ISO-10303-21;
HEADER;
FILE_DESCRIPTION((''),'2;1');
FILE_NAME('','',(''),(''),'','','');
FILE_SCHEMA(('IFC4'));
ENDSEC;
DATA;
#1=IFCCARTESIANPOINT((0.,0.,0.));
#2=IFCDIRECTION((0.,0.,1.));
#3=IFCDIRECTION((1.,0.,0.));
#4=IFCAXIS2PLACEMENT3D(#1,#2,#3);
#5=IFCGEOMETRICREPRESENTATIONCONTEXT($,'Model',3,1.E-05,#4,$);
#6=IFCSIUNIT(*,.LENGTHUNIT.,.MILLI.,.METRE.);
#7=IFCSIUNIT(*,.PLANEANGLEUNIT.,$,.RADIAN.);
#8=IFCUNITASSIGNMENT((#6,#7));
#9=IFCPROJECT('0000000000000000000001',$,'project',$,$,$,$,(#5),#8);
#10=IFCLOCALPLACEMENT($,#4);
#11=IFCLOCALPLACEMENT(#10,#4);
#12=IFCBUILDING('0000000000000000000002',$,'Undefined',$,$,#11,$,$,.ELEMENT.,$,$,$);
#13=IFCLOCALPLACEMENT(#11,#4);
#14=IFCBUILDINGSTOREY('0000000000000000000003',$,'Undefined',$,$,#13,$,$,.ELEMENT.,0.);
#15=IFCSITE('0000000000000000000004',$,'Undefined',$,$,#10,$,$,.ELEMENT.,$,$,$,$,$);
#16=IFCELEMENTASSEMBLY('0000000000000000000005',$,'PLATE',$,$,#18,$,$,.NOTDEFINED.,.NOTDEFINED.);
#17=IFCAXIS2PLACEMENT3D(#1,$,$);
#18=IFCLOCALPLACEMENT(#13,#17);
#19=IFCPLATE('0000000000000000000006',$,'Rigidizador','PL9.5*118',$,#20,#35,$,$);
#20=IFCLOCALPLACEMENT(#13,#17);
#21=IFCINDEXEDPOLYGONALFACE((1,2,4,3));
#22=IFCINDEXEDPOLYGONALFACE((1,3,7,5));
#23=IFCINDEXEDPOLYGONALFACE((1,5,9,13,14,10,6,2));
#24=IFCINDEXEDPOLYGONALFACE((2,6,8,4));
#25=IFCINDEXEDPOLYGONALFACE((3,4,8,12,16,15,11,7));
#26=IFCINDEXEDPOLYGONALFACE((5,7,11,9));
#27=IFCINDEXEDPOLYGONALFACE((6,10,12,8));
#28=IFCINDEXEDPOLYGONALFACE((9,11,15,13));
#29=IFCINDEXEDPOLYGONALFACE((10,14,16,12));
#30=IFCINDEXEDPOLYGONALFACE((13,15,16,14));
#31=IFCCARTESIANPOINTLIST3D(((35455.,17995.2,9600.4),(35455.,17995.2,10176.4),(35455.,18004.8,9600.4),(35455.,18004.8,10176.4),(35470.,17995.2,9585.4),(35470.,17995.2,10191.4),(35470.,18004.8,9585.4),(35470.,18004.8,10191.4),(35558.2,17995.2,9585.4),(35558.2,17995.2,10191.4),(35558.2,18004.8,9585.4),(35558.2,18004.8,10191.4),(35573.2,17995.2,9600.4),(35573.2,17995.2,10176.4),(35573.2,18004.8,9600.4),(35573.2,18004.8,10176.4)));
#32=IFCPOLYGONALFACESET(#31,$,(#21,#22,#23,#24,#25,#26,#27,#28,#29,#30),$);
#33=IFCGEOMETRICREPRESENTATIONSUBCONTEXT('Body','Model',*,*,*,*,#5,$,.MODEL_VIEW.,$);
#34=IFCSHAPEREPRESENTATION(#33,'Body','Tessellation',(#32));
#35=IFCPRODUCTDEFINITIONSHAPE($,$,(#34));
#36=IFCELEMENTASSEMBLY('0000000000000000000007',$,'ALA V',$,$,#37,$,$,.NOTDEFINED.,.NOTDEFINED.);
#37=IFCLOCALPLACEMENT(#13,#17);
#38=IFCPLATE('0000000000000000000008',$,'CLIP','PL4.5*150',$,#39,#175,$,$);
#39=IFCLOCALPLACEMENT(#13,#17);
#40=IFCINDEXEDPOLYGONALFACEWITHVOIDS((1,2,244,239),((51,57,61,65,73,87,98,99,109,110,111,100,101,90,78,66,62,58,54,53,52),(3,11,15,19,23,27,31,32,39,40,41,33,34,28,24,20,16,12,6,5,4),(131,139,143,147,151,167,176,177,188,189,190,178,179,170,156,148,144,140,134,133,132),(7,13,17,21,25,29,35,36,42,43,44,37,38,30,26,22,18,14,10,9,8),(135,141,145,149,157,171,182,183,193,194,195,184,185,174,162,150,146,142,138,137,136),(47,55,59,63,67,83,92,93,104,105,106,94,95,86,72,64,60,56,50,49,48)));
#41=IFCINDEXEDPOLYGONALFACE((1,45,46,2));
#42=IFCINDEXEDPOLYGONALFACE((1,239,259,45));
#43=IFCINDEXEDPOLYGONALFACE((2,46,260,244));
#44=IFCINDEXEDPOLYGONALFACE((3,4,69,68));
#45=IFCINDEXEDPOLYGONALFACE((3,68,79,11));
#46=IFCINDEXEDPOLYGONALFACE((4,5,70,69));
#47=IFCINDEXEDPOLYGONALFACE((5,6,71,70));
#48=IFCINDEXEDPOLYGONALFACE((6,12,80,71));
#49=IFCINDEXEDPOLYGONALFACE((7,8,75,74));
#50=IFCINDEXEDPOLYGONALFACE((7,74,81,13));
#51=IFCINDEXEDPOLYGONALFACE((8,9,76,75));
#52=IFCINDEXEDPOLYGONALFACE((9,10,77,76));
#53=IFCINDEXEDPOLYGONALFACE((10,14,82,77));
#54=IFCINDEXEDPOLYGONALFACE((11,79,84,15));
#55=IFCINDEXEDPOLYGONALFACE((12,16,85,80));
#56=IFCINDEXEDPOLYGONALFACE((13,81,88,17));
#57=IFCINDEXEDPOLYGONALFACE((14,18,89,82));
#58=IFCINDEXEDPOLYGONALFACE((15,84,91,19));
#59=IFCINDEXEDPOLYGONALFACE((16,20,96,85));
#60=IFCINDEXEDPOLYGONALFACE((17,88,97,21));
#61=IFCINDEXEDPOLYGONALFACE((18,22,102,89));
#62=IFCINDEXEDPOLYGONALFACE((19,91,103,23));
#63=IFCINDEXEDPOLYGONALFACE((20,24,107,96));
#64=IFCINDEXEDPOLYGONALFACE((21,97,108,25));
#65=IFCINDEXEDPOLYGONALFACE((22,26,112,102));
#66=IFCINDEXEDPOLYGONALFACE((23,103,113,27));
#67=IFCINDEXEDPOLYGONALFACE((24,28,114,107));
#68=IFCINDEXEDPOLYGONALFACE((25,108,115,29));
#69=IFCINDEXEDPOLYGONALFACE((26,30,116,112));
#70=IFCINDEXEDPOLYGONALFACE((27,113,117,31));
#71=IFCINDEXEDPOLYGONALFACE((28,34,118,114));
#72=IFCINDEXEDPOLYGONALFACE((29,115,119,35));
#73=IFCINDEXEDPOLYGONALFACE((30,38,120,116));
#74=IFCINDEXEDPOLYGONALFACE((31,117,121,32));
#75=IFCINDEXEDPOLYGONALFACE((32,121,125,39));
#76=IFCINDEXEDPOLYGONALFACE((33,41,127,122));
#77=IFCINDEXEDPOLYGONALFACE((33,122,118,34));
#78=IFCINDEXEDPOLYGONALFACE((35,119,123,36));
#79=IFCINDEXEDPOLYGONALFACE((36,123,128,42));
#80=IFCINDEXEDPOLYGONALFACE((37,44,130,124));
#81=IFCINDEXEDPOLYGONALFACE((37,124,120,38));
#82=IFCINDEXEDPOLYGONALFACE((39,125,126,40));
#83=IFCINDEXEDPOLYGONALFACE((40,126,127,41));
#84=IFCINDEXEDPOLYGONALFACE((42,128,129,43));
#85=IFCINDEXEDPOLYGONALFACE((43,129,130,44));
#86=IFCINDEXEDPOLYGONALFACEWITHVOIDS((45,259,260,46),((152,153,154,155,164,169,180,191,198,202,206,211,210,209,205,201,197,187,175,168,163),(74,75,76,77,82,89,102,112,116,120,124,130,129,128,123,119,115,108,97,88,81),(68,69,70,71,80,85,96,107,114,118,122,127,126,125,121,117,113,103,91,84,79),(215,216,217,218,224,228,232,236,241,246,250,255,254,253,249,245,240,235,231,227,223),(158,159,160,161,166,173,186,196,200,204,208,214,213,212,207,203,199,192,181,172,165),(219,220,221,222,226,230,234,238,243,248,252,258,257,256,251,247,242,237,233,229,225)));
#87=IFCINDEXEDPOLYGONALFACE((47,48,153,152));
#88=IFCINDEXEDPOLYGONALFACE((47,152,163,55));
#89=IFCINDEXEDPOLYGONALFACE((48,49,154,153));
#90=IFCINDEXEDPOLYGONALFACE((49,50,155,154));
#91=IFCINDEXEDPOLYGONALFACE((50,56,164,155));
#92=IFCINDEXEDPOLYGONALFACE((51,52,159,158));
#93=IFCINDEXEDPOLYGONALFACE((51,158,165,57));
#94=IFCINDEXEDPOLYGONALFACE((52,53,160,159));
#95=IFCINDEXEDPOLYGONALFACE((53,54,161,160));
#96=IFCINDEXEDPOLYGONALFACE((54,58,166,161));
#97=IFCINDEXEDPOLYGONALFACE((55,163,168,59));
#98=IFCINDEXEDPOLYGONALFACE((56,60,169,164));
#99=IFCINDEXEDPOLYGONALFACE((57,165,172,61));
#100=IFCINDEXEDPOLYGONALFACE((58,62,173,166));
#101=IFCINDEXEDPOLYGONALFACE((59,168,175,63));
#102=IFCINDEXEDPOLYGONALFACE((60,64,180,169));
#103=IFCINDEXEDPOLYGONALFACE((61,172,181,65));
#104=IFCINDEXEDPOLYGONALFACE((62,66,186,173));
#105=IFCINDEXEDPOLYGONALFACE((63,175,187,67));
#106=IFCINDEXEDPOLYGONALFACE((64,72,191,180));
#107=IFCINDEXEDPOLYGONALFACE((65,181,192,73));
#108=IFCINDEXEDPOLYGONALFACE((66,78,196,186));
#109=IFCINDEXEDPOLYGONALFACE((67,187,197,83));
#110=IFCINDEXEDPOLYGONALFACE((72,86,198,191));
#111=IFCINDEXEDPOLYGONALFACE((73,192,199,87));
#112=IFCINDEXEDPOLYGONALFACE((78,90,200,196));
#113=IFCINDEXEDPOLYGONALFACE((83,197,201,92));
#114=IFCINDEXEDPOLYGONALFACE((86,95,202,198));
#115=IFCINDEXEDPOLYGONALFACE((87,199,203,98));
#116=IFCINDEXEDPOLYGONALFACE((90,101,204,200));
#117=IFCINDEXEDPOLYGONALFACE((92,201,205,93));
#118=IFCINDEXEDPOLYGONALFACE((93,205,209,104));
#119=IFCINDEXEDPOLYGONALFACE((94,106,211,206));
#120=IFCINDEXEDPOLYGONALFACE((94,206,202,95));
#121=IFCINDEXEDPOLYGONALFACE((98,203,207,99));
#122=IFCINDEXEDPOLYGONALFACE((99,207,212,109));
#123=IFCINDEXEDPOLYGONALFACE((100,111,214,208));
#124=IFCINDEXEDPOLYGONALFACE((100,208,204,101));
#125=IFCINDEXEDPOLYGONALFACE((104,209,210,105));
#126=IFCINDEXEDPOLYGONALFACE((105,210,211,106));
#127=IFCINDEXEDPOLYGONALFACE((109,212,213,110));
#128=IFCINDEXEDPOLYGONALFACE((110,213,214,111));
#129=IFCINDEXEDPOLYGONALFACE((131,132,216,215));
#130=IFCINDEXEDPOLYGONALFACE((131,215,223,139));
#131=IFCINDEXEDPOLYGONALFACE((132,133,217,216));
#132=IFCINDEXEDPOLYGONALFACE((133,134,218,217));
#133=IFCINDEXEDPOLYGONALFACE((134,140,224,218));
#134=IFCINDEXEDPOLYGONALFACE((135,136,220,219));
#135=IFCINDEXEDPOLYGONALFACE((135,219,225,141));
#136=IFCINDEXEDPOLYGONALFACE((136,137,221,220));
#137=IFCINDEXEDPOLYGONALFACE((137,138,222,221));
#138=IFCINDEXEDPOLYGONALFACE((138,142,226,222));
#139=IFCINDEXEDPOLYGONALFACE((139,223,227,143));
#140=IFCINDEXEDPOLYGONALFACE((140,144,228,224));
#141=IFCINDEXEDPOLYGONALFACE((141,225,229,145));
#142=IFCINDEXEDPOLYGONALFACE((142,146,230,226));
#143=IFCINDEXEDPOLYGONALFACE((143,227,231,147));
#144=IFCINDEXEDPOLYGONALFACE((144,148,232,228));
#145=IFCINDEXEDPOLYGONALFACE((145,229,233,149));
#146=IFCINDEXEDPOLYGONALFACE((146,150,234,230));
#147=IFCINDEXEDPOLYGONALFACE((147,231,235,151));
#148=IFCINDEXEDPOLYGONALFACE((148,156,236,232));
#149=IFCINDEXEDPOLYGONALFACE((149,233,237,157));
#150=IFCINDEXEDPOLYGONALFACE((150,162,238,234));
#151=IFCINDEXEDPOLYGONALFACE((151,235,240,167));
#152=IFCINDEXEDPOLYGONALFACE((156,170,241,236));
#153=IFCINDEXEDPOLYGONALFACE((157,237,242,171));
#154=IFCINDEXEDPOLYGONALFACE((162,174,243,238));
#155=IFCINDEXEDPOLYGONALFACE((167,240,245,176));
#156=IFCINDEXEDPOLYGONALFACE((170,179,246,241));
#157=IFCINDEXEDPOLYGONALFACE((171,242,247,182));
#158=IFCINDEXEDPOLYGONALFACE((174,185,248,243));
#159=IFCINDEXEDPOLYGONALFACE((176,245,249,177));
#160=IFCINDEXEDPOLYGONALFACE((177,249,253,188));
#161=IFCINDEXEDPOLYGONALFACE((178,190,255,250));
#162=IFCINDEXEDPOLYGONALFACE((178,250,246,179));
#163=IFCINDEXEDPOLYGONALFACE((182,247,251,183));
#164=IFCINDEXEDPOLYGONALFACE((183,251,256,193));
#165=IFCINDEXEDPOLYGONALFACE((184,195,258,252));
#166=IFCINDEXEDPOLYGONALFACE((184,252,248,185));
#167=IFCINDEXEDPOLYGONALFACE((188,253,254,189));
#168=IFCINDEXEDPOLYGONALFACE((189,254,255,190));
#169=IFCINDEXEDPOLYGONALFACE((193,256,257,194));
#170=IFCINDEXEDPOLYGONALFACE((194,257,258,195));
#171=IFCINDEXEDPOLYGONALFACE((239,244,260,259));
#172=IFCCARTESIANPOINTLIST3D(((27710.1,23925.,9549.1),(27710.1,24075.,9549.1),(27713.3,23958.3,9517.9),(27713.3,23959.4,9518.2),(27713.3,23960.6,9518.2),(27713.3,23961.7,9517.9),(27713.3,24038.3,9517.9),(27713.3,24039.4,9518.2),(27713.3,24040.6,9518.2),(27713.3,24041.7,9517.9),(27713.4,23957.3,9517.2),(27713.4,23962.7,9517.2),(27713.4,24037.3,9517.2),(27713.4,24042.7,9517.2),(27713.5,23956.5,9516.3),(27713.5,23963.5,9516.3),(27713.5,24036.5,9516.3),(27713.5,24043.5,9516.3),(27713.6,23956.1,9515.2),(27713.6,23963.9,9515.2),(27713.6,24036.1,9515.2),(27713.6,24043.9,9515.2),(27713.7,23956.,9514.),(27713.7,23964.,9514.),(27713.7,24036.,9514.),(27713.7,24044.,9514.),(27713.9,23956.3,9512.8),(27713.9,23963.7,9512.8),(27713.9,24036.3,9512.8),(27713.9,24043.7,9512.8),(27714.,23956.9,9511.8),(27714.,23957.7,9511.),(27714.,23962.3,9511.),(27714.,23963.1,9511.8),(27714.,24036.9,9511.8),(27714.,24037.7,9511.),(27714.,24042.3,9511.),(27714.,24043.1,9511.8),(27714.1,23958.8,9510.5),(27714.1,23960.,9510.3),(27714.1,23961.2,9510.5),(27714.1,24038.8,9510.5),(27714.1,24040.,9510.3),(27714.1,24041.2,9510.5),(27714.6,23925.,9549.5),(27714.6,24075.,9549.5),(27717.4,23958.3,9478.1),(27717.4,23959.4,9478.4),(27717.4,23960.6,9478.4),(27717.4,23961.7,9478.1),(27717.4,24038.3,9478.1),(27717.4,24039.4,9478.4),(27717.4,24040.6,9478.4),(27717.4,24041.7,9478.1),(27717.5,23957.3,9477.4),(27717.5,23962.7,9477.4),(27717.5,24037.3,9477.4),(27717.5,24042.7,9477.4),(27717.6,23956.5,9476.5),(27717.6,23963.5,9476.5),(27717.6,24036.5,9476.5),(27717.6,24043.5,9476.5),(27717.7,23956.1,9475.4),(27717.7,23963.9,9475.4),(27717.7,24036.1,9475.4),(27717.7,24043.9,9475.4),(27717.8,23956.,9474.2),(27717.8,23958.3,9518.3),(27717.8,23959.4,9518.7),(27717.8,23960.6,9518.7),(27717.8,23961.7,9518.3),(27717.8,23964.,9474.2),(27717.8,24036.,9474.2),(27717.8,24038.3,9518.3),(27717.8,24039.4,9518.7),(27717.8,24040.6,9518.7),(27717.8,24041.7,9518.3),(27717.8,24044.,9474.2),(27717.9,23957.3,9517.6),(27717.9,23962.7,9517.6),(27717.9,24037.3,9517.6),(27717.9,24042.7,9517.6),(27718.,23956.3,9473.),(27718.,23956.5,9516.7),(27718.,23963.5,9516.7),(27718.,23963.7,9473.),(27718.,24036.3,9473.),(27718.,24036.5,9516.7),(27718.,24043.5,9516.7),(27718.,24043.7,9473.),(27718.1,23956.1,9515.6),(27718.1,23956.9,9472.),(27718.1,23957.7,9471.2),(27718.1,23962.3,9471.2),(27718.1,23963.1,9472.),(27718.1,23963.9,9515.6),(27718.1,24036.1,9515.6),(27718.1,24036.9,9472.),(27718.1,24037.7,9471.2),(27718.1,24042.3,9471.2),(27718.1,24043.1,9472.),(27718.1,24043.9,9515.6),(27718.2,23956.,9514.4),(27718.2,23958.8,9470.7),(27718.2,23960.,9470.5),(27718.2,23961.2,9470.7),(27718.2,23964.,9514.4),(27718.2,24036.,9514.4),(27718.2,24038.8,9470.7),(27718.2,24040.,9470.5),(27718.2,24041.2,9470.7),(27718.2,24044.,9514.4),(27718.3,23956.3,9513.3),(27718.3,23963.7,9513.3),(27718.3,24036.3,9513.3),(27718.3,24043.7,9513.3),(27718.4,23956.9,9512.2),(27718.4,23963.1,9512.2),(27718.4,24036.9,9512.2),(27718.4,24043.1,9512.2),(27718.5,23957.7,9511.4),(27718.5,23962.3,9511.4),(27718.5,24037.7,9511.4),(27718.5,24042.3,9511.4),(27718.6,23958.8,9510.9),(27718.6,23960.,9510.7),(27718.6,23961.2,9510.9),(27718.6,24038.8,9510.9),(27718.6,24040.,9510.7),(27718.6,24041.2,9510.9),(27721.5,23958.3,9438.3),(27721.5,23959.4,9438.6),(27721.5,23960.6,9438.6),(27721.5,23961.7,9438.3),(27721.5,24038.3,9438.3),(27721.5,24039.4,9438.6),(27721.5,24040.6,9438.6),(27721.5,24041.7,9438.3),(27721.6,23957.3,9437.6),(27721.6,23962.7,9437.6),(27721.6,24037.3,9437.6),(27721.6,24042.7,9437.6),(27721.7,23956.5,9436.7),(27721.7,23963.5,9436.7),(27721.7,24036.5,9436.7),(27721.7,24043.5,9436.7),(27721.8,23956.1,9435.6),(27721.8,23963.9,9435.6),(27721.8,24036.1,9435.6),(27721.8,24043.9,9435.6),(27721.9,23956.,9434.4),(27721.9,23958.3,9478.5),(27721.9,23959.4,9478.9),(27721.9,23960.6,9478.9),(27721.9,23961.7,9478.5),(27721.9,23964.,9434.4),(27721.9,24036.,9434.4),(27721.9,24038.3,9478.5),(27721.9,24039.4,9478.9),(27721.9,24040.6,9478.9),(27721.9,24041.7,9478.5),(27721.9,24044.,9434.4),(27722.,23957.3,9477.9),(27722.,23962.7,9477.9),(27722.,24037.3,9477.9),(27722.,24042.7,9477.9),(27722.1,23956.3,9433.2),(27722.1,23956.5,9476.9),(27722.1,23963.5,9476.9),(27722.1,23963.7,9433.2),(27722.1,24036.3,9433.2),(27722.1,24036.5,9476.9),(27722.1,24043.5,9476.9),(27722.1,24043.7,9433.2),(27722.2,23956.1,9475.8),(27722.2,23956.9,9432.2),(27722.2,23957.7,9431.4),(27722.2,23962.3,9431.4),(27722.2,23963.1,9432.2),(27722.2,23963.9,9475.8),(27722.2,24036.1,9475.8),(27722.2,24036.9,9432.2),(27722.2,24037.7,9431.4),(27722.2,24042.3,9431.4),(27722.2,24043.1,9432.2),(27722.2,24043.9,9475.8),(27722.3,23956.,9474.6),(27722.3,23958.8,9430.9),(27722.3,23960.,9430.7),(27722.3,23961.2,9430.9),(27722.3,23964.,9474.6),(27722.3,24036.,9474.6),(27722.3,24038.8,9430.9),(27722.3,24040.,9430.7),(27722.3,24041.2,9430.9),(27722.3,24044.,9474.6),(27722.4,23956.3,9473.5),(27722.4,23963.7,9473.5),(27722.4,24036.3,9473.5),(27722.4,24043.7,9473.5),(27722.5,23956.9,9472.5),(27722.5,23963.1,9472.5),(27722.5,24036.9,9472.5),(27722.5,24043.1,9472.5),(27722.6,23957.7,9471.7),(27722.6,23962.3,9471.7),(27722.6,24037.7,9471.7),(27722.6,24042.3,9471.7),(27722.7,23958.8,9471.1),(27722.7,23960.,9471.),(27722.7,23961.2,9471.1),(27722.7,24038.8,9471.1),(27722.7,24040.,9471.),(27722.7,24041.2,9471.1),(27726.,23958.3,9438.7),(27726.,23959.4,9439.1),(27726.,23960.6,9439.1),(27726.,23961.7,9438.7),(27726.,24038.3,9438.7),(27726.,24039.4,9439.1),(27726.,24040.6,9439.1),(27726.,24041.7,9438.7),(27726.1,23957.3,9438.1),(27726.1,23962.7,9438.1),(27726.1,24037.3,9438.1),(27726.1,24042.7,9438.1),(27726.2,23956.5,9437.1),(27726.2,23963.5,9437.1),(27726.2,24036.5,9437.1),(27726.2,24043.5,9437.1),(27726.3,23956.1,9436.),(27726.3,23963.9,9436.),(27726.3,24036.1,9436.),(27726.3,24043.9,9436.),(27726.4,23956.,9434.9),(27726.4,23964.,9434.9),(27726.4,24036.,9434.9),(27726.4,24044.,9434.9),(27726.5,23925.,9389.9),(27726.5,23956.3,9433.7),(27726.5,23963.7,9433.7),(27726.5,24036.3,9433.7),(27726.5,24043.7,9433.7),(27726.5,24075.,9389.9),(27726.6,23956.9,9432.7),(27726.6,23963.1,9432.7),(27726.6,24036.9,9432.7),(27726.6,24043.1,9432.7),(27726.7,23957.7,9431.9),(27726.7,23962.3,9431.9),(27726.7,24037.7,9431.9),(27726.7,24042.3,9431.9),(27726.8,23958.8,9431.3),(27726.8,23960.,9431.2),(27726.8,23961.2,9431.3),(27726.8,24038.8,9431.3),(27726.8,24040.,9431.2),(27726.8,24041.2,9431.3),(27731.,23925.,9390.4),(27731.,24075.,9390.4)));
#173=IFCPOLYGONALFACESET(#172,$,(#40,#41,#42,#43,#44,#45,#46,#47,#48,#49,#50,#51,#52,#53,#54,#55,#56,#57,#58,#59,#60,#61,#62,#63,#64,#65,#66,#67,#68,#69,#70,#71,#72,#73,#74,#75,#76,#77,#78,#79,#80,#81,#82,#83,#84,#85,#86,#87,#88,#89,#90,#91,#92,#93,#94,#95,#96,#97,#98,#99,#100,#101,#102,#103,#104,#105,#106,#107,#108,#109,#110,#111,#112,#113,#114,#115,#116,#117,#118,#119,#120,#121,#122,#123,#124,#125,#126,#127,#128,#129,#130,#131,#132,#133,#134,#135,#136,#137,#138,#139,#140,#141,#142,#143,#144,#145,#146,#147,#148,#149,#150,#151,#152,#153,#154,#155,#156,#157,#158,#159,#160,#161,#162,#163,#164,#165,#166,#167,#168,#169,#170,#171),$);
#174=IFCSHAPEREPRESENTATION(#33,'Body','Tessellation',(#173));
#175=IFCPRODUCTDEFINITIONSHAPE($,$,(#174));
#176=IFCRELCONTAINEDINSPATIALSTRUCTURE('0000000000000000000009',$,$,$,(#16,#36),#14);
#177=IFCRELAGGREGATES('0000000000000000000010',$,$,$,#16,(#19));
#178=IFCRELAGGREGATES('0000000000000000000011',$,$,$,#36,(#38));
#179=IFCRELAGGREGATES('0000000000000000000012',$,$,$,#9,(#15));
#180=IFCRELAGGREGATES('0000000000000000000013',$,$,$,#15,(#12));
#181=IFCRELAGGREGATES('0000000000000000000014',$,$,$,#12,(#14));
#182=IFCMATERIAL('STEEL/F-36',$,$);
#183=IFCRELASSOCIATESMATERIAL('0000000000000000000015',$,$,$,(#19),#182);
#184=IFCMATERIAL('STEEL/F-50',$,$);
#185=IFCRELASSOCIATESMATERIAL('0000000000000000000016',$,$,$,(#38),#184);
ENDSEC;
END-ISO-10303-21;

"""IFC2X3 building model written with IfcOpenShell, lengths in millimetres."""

from ifc_helpers import new_model, si_unit, frame, origin_with_axes, origin_2d_with_axis, place, context, subcontext, project, spatial, polyline, circle, outline, extrude, source, transform, mapped, material, element, aggregate, save


model = new_model("IFC2X3")

# Units and contexts
model_context = context("Model", 3, precision=1e-05, world=origin_with_axes())
body_context = subcontext(model_context, "Body", "Model", "MODEL_VIEW")
ifc_project = project(units=[si_unit("LENGTHUNIT", "METRE", prefix="MILLI"), si_unit("PLANEANGLEUNIT", "RADIAN")], contexts=[model_context])

# Site, building, storey
site_placement = place(None, origin_with_axes())
site = spatial("IfcSite", under=ifc_project, at=site_placement, Name="Undefined", CompositionType="ELEMENT")
building_placement = place(site_placement, origin_with_axes())
building = spatial("IfcBuilding", under=site, at=building_placement, Name="Undefined", CompositionType="ELEMENT")
storey_placement = place(building_placement, origin_with_axes())
storey = spatial("IfcBuildingStorey", under=building, at=storey_placement, Name="Undefined", CompositionType="ELEMENT", Elevation=0.0)

# Element assembly
assembly_1_placement = place(storey_placement, origin_with_axes())
assembly_1 = element("IfcElementAssembly", 1, at=assembly_1_placement, inside=storey, Name="PLATE", AssemblyPlace="NOTDEFINED", PredefinedType="NOTDEFINED")
ifc_material_1 = material(Name="STEEL/F-36")

# Shared definitions
ifc_material_2 = material(Name="STEEL/F-50")

# Plate
plate_1_placement = place(assembly_1_placement, frame((35455.0, 18000.0, 9585.4), z_axis=(0.0, -1.0, 0.0), x_axis=(1.0, 0.0, 0.0)))
plate_1 = element("IfcPlate", 2, at=plate_1_placement, material=ifc_material_1, Name="Rigidizador", Description="PL9.5*118", context=body_context, shape_type="SweptSolid", body=[
    extrude(outline(polyline([(0.0, 15.0), (15.0, 0.0), (103.2, 0.0), (118.2, 15.0), (118.2, 591.0), (103.2, 606.0), (15.0, 606.0), (0.0, 591.0), (0.0, 15.0)])), frame((0.0, 0.0, -4.8), z_axis=(0.0, 0.0, 1.0), x_axis=(1.0, 0.0, 0.0)), (0.0, 0.0, 1.0), 9.5),
])
aggregate(assembly_1, [plate_1])

# Element assembly, plate, openings
assembly_2_placement = place(storey_placement, origin_with_axes())
assembly_2 = element("IfcElementAssembly", 3, at=assembly_2_placement, inside=storey, Name="ALA V", AssemblyPlace="NOTDEFINED", PredefinedType="NOTDEFINED")
plate_2_placement = place(assembly_2_placement, frame((27712.4, 23925.0, 9549.3), z_axis=(0.994727, 0.0, 0.102562), x_axis=(0.102562, 0.0, -0.994727)))
plate_2 = element("IfcPlate", 4, at=plate_2_placement, material=ifc_material_2, Name="CLIP", Description="PL4.5*150", context=body_context, shape_type="SweptSolid", body=[
    extrude(outline(polyline([(0.0, 0.0), (160.0, 0.0), (160.0, 150.0), (0.0, 150.0), (0.0, 0.0)])), frame((0.0, 0.0, -2.2), z_axis=(0.0, 0.0, 1.0), x_axis=(1.0, 0.0, 0.0)), (0.0, 0.0, 1.0), 4.5),
])
shared_shape_1 = source(origin_with_axes(), body_context, "Body", "SweptSolid", [
    extrude(circle(Radius=4.0, at=origin_2d_with_axis()), frame((0.0, -4.6, 0.0), z_axis=(0.0, 1.0, 0.0), x_axis=(1.0, 0.0, 0.0)), (0.0, 0.0, 1.0), 4.7),
])
opening_1_placement = place(assembly_2_placement, frame((27713.7, 24040.0, 9514.3), z_axis=(0.0, 1.0, 0.0), x_axis=(0.102562, 0.0, -0.994727)))
element("IfcOpeningElement", 5, at=opening_1_placement, cuts=plate_2, ObjectType="Opening", context=body_context, shape_type="MappedRepresentation", body=[
    mapped(shared_shape_1, transform((0.0, 0.0, 0.0))),
    mapped(shared_shape_1, transform((40.0, 0.0, 0.0))),
    mapped(shared_shape_1, transform((80.0, 0.0, 0.0))),
])
opening_2_placement = place(assembly_2_placement, frame((27713.7, 23960.0, 9514.3), z_axis=(0.0, 1.0, 0.0), x_axis=(0.102562, 0.0, -0.994727)))
element("IfcOpeningElement", 6, at=opening_2_placement, cuts=plate_2, ObjectType="Opening", context=body_context, shape_type="MappedRepresentation", body=[
    mapped(shared_shape_1, transform((0.0, 0.0, 0.0))),
    mapped(shared_shape_1, transform((40.0, 0.0, 0.0))),
    mapped(shared_shape_1, transform((80.0, 0.0, 0.0))),
])

aggregate(assembly_2, [plate_2])

save(model, "model.ifc")
